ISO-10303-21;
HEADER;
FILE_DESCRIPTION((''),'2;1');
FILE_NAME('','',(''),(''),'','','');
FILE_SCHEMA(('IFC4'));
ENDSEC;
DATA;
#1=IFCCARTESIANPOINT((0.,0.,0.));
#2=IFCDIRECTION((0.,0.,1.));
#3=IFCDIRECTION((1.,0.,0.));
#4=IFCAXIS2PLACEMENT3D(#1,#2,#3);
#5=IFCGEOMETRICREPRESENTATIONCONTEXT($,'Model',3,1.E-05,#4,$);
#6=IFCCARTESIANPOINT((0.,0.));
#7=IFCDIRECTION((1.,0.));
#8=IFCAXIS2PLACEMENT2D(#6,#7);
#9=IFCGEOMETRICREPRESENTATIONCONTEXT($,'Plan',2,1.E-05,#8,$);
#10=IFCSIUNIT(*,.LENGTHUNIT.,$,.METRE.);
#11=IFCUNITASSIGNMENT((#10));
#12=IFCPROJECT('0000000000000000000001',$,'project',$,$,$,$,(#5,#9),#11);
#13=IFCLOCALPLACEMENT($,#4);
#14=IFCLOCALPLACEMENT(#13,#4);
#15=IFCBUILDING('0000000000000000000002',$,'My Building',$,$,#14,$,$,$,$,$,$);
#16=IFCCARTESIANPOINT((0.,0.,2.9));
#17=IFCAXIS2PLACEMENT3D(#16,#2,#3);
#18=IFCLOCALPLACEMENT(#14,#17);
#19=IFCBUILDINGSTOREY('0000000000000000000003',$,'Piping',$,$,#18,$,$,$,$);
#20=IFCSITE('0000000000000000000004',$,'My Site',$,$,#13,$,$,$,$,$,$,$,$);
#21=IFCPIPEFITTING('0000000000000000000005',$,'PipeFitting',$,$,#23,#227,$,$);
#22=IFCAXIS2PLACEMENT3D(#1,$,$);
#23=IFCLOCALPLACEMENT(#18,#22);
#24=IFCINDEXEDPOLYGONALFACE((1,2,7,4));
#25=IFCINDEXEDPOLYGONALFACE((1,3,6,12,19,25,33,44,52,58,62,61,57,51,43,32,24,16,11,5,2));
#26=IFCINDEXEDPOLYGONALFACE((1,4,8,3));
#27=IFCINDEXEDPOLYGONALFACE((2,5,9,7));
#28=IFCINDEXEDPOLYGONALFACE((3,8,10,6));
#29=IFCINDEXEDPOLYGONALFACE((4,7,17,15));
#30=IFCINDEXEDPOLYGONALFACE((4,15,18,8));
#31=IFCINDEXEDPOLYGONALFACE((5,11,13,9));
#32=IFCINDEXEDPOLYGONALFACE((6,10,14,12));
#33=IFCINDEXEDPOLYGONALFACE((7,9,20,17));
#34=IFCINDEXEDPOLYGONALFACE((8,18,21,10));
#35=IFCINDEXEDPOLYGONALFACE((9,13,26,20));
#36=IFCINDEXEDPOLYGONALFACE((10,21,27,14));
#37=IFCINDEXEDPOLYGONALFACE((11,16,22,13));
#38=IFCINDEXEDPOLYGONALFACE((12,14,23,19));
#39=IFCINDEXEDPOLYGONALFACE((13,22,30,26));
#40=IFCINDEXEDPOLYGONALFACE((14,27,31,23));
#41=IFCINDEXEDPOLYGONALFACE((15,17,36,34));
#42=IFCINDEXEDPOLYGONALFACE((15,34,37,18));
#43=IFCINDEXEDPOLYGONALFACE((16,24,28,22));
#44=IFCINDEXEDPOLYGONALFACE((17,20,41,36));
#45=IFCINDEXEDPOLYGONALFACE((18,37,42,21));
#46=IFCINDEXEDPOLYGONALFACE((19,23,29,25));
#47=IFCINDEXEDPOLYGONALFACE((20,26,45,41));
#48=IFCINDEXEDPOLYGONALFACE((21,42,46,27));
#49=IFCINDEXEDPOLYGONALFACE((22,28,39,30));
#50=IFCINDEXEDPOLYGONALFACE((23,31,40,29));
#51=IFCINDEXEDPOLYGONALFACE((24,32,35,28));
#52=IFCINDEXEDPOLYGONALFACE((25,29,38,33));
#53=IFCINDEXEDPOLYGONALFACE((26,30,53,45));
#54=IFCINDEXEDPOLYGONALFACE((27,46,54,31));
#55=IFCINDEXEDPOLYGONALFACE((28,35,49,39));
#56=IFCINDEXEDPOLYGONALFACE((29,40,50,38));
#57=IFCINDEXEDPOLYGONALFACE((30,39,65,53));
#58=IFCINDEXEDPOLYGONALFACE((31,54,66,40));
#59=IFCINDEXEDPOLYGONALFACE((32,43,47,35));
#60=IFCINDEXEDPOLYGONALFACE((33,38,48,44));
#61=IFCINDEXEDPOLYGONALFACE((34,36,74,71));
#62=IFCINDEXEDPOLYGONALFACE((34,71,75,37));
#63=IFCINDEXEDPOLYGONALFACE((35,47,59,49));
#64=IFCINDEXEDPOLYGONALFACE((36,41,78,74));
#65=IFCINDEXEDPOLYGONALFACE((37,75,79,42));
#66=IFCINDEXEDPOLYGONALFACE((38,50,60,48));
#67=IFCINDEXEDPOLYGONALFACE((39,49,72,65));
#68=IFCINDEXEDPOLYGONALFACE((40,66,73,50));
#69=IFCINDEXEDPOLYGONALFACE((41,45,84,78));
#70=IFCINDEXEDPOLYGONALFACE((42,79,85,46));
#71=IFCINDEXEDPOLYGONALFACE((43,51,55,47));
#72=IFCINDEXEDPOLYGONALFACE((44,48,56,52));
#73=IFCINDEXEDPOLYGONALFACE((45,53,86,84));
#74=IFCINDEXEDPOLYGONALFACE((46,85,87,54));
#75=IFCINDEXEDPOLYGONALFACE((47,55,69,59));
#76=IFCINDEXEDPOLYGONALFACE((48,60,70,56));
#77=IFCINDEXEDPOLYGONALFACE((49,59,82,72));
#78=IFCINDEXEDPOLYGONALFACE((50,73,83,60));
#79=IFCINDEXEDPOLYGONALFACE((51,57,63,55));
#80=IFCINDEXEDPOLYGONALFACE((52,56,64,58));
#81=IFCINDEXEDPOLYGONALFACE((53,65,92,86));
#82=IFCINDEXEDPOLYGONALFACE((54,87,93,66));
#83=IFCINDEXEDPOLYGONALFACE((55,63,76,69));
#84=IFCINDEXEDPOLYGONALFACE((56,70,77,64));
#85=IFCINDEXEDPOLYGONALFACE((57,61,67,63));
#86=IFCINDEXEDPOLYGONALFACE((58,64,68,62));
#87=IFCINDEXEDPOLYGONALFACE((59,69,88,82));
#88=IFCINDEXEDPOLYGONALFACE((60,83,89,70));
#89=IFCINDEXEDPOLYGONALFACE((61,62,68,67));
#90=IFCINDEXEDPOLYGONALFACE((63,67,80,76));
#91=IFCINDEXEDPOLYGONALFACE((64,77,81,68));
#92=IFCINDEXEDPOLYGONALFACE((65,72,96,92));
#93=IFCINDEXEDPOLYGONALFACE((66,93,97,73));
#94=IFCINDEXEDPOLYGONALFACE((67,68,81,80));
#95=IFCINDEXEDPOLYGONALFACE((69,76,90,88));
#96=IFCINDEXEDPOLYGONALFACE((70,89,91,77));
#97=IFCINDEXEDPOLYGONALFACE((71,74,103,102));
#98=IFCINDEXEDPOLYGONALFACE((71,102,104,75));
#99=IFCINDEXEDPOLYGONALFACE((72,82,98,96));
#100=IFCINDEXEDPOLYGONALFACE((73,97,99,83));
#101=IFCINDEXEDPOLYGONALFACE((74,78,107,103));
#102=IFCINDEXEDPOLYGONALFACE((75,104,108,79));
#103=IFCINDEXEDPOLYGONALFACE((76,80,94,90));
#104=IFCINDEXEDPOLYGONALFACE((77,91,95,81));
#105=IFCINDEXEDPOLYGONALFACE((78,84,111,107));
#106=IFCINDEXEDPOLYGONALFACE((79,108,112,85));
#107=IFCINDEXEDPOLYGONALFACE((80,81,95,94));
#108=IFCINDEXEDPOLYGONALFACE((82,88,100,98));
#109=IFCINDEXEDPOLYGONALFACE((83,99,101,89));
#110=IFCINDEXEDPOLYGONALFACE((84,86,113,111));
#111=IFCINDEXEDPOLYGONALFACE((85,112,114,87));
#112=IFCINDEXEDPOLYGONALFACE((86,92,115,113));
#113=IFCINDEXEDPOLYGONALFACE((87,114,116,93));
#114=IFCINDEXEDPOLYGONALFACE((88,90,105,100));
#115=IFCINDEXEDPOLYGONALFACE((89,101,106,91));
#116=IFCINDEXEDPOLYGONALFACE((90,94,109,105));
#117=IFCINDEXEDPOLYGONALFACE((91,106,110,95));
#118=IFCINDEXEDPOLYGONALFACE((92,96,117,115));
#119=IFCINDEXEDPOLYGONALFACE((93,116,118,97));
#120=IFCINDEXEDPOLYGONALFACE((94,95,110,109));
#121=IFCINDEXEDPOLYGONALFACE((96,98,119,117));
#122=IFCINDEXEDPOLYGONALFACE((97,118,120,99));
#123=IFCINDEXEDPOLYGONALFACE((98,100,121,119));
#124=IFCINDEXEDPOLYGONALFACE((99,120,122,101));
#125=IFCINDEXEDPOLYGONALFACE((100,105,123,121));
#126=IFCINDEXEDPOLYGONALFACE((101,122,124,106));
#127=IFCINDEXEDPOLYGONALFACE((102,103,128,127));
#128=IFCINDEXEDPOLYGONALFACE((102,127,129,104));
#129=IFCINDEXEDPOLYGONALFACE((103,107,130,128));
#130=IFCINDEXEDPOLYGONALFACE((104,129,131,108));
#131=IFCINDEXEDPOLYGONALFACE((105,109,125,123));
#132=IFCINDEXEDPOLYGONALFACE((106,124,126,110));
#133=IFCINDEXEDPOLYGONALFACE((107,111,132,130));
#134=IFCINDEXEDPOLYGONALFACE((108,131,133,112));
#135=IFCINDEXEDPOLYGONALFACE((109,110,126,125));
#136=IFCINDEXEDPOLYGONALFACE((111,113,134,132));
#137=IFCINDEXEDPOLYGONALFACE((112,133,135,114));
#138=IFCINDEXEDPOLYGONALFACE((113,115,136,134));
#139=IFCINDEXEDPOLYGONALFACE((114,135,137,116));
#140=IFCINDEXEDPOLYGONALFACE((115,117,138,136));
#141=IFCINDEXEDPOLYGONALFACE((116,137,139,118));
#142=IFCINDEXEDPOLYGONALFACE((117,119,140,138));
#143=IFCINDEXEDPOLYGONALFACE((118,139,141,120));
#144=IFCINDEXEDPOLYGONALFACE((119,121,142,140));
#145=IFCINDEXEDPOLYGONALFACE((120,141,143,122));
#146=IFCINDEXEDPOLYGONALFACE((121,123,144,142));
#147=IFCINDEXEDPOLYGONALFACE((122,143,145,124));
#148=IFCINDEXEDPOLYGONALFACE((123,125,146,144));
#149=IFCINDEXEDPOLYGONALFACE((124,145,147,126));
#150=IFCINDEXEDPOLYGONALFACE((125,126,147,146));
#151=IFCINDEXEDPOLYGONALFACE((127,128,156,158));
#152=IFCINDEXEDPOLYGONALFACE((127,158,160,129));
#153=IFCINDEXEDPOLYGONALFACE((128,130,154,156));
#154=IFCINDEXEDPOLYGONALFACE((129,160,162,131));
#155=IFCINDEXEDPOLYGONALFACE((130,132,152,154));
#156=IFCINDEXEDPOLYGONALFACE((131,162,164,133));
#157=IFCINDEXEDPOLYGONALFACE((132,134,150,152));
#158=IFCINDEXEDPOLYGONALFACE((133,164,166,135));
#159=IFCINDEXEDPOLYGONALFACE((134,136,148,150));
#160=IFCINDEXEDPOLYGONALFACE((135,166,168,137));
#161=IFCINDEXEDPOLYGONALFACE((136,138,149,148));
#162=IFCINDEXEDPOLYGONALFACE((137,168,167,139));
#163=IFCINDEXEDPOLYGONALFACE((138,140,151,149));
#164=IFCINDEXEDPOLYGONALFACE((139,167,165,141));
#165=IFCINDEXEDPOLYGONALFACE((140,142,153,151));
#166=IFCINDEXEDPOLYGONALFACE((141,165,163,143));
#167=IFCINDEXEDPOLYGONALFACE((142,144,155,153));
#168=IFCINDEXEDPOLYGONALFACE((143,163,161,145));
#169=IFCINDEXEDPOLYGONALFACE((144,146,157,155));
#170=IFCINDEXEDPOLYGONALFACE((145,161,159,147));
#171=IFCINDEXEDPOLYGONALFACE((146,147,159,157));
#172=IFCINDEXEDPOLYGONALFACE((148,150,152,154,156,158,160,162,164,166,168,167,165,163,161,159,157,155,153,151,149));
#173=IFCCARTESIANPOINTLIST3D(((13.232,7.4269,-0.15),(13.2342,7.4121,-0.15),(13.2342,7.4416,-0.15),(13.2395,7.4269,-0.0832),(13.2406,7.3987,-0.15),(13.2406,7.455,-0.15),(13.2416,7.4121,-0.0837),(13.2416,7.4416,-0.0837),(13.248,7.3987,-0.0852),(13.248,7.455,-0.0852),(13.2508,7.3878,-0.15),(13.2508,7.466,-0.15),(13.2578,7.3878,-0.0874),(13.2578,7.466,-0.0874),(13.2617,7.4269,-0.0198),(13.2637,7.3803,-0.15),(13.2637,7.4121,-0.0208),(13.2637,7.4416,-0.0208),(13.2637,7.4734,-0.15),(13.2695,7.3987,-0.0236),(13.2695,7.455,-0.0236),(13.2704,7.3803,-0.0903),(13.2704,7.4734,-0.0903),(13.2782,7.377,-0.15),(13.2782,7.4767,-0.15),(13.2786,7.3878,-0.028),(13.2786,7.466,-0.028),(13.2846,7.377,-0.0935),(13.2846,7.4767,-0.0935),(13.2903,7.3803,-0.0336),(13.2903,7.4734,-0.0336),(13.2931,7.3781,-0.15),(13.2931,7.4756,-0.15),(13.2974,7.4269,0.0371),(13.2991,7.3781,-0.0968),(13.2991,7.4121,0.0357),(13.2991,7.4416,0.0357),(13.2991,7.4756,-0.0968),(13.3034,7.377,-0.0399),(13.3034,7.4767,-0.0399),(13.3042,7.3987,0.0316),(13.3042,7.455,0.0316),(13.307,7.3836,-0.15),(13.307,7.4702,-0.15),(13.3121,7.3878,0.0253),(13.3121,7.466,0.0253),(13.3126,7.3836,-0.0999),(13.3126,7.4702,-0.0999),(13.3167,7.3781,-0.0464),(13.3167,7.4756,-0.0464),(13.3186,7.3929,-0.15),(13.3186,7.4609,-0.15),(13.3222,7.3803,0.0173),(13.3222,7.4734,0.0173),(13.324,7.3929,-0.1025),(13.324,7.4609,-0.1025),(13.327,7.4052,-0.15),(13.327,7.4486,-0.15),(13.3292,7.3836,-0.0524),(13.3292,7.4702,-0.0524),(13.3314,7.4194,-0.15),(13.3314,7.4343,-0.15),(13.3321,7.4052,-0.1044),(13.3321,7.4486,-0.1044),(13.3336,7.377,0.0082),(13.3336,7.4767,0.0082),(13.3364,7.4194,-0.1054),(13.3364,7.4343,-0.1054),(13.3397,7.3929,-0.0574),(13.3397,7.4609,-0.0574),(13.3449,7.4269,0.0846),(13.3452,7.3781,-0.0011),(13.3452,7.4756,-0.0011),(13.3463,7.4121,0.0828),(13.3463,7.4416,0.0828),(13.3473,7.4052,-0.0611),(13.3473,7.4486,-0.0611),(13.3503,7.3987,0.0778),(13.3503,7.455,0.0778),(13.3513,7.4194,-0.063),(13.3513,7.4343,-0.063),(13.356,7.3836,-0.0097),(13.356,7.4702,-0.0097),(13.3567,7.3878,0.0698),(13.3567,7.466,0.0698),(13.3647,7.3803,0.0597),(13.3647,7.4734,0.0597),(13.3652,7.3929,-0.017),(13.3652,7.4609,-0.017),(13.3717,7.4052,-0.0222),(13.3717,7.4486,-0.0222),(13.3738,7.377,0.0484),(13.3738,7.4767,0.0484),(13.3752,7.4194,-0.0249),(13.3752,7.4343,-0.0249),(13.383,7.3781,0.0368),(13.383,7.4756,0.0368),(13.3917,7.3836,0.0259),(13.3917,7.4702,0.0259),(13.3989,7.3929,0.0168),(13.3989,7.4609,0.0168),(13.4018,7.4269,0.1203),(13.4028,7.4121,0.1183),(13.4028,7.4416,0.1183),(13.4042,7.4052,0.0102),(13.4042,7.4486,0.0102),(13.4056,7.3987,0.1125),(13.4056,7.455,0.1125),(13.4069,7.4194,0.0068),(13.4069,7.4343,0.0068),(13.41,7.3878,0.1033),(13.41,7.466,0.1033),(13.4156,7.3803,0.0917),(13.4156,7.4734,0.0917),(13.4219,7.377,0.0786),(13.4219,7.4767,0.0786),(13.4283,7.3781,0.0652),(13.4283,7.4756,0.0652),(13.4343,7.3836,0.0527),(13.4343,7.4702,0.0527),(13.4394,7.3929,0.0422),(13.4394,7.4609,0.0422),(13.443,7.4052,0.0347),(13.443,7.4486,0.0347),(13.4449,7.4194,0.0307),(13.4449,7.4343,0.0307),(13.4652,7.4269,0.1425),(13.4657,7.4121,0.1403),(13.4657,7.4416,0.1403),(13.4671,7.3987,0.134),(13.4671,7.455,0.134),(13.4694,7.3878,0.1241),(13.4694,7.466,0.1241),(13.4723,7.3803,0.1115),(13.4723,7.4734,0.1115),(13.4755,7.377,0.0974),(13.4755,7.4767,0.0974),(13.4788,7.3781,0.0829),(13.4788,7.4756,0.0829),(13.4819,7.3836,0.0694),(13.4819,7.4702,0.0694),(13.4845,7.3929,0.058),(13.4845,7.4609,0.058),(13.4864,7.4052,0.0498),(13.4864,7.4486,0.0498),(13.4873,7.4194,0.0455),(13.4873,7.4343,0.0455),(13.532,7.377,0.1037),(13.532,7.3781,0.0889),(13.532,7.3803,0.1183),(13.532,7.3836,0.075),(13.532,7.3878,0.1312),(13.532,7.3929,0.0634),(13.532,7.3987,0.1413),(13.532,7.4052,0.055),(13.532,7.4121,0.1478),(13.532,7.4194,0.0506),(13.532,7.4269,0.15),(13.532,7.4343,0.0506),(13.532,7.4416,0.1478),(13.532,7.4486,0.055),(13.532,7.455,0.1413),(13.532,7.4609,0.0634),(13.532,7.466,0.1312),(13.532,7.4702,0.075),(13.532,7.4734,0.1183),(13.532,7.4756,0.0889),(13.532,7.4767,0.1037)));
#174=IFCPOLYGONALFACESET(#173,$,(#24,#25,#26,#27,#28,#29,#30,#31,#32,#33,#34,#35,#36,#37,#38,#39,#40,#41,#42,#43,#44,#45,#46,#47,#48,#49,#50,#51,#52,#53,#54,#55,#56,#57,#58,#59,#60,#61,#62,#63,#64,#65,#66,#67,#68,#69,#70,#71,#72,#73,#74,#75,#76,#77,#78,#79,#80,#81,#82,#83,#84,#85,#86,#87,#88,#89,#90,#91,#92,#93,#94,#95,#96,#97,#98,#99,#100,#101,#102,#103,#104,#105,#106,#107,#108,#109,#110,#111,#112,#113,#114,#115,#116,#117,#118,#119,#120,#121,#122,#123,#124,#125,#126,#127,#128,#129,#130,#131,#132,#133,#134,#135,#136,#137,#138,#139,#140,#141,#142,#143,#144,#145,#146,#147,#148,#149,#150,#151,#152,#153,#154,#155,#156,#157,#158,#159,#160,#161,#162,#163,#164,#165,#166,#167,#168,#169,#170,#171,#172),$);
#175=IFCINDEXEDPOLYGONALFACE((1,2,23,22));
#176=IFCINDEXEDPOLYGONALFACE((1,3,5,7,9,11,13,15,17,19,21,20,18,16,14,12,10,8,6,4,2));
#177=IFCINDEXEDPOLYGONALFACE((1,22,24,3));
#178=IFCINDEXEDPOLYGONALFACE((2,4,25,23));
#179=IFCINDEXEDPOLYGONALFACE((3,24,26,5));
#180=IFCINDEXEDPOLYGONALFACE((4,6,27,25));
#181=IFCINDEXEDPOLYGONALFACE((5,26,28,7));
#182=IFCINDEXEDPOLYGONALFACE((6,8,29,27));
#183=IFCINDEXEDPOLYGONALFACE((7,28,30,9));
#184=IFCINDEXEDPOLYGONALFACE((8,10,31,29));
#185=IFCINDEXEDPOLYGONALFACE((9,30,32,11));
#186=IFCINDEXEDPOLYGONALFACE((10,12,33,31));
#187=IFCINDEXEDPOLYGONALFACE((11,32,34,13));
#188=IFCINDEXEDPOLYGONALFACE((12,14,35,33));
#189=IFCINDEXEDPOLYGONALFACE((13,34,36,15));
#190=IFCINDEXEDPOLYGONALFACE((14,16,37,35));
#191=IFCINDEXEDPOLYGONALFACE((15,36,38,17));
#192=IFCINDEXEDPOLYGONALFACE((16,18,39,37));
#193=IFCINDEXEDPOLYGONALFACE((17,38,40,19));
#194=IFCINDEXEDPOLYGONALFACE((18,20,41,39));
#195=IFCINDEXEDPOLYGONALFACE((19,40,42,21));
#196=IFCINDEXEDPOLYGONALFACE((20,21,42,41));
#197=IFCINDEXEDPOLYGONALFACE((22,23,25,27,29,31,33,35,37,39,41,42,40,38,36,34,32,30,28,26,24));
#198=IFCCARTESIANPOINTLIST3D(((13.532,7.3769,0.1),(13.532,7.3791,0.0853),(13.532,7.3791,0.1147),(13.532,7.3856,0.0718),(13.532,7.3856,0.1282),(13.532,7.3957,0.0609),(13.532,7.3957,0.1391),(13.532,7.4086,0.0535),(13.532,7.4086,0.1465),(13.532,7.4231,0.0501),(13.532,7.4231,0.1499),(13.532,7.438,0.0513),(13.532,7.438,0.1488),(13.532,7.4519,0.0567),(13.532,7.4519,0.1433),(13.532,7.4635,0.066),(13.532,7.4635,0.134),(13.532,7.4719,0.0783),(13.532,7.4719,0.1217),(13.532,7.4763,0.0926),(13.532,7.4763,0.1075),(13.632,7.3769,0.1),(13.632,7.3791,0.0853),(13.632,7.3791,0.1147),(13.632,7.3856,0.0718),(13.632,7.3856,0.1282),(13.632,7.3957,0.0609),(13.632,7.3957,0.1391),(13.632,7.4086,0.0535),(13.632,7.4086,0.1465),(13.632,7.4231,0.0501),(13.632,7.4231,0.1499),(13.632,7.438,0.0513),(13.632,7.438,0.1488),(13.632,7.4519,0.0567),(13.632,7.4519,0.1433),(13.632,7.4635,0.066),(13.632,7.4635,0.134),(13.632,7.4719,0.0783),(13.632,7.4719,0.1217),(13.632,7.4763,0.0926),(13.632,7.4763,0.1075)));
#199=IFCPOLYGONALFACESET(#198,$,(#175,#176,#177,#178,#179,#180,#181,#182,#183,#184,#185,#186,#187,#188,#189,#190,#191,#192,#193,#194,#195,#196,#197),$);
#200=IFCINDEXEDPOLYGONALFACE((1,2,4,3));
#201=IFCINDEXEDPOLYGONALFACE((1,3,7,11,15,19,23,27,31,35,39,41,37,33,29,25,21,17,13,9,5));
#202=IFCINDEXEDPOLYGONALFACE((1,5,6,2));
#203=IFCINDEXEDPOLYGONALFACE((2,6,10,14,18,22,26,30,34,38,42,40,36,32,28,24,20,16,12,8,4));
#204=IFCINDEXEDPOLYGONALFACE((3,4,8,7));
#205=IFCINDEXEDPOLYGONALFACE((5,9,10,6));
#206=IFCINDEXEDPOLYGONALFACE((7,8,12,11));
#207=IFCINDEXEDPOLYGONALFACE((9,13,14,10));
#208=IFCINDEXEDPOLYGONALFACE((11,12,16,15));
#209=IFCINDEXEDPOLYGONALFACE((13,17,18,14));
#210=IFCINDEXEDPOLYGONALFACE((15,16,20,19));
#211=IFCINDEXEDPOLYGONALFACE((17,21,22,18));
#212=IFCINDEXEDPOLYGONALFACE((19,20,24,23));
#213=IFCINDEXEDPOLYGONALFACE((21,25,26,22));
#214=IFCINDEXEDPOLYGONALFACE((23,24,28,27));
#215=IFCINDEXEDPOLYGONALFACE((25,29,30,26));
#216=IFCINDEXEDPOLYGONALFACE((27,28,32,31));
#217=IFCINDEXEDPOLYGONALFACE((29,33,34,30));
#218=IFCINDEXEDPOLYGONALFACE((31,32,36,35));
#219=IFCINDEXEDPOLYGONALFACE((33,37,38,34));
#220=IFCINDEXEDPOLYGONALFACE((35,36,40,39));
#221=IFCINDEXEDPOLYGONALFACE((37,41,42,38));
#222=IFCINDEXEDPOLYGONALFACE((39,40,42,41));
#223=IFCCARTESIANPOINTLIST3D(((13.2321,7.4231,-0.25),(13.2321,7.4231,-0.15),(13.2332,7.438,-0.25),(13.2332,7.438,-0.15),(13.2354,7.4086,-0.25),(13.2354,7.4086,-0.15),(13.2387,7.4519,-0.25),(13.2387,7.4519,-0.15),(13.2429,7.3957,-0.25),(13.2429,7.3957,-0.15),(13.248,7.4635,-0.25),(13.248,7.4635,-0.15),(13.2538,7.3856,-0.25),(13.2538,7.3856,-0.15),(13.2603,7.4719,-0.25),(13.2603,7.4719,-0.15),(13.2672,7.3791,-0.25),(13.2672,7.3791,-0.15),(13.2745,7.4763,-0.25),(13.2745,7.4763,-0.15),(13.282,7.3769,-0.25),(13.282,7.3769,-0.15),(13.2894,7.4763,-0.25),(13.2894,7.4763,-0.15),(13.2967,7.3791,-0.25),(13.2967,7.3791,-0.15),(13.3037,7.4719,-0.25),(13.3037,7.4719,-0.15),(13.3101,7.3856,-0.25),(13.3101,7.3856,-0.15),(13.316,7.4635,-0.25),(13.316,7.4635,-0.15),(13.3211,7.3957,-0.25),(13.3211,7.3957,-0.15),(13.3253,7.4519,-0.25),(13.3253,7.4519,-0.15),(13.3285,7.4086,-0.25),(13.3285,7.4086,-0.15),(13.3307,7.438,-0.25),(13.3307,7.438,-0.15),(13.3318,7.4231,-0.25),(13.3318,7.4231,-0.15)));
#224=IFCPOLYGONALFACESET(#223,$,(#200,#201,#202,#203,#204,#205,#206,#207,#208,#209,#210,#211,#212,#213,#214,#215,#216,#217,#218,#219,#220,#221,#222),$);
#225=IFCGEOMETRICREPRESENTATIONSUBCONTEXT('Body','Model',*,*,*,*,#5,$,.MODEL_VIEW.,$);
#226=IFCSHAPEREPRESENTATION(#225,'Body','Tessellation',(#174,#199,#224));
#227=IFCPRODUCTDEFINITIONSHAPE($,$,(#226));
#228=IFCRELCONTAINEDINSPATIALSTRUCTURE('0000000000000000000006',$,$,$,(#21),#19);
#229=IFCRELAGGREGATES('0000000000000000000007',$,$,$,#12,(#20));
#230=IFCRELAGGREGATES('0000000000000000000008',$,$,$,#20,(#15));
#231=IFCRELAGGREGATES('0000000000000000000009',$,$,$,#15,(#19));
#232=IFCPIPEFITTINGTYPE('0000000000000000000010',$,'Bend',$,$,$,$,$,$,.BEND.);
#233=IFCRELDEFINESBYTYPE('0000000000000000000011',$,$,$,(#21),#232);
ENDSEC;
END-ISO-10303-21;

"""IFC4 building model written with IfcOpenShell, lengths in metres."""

from ifc_helpers import new_model, entity, si_unit, frame, origin_with_axes, origin_2d_with_axis, place, context, subcontext, project, spatial, circle, extrude, source, transform, mapped, type_object, type_shapes, element, save


model = new_model("IFC4")

# Units and contexts
model_context = context("Model", 3, precision=1e-05, world=origin_with_axes())
plan_context = context("Plan", 2, precision=1e-05, world=origin_2d_with_axis())
body_context = subcontext(model_context, "Body", "Model", "MODEL_VIEW")
ifc_project = project(units=[si_unit("LENGTHUNIT", "METRE")], contexts=[model_context, plan_context])

# Site, building, storey
site_placement = place(None, origin_with_axes())
site = spatial("IfcSite", under=ifc_project, at=site_placement, Name="My Site")
building_placement = place(site_placement, origin_with_axes())
building = spatial("IfcBuilding", under=site, at=building_placement, Name="My Building")
storey_placement = place(building_placement, frame((0.0, 0.0, 2.9), z_axis=(0.0, 0.0, 1.0), x_axis=(1.0, 0.0, 0.0)))
storey = spatial("IfcBuildingStorey", under=building, at=storey_placement, Name="Piping")

# Pipe fitting
pipe_fitting_type = type_object("IfcPipeFittingType", Name="Bend", PredefinedType="BEND")
shared_shape = source(origin_with_axes(), body_context, "Body", "SolidModel", [
    entity("IfcSweptDiskSolid", entity("IfcIndexedPolyCurve", entity("IfcCartesianPointList3D", [[0.0, 0.0, 0.1], [0.0, -0.0732, 0.2768], [0.0, -0.25, 0.35]]), [entity("IfcArcIndex", [1, 2, 3])]), 0.05),
    extrude(circle(Radius=0.05), origin_with_axes(), (0.0, 0.0, 1.0), 0.1),
    extrude(circle(Radius=0.05), frame((0.0, -0.25, 0.35), z_axis=(0.0, -1.0, -0.000001), x_axis=(1.0, 0.0, 0.0)), (0.0, 0.0, 1.0), 0.1),
])
type_shapes(pipe_fitting_type, [shared_shape])
for number, where, z_axis, x_axis, name in (
    (1, (13.632, 7.4269, 0.1), (-1.0, 0.0, 0.000001), (0.0, -1.0, 0.0), "PipeFitting"),
):
    element("IfcPipeFitting", number, at=place(storey_placement, frame(where, z_axis=z_axis, x_axis=x_axis)), inside=storey, type_object=pipe_fitting_type, Name=name, context=body_context, shape_type="MappedRepresentation", body=[
        mapped(shared_shape, transform((0.0, 0.0, 0.0), x_axis=(1.0, 0.0, 0.0), y_axis=(0.0, 1.0, 0.0), z_axis=(0.0, 0.0, 1.0), scale=1.0)),
    ])

save(model, "model.ifc")
